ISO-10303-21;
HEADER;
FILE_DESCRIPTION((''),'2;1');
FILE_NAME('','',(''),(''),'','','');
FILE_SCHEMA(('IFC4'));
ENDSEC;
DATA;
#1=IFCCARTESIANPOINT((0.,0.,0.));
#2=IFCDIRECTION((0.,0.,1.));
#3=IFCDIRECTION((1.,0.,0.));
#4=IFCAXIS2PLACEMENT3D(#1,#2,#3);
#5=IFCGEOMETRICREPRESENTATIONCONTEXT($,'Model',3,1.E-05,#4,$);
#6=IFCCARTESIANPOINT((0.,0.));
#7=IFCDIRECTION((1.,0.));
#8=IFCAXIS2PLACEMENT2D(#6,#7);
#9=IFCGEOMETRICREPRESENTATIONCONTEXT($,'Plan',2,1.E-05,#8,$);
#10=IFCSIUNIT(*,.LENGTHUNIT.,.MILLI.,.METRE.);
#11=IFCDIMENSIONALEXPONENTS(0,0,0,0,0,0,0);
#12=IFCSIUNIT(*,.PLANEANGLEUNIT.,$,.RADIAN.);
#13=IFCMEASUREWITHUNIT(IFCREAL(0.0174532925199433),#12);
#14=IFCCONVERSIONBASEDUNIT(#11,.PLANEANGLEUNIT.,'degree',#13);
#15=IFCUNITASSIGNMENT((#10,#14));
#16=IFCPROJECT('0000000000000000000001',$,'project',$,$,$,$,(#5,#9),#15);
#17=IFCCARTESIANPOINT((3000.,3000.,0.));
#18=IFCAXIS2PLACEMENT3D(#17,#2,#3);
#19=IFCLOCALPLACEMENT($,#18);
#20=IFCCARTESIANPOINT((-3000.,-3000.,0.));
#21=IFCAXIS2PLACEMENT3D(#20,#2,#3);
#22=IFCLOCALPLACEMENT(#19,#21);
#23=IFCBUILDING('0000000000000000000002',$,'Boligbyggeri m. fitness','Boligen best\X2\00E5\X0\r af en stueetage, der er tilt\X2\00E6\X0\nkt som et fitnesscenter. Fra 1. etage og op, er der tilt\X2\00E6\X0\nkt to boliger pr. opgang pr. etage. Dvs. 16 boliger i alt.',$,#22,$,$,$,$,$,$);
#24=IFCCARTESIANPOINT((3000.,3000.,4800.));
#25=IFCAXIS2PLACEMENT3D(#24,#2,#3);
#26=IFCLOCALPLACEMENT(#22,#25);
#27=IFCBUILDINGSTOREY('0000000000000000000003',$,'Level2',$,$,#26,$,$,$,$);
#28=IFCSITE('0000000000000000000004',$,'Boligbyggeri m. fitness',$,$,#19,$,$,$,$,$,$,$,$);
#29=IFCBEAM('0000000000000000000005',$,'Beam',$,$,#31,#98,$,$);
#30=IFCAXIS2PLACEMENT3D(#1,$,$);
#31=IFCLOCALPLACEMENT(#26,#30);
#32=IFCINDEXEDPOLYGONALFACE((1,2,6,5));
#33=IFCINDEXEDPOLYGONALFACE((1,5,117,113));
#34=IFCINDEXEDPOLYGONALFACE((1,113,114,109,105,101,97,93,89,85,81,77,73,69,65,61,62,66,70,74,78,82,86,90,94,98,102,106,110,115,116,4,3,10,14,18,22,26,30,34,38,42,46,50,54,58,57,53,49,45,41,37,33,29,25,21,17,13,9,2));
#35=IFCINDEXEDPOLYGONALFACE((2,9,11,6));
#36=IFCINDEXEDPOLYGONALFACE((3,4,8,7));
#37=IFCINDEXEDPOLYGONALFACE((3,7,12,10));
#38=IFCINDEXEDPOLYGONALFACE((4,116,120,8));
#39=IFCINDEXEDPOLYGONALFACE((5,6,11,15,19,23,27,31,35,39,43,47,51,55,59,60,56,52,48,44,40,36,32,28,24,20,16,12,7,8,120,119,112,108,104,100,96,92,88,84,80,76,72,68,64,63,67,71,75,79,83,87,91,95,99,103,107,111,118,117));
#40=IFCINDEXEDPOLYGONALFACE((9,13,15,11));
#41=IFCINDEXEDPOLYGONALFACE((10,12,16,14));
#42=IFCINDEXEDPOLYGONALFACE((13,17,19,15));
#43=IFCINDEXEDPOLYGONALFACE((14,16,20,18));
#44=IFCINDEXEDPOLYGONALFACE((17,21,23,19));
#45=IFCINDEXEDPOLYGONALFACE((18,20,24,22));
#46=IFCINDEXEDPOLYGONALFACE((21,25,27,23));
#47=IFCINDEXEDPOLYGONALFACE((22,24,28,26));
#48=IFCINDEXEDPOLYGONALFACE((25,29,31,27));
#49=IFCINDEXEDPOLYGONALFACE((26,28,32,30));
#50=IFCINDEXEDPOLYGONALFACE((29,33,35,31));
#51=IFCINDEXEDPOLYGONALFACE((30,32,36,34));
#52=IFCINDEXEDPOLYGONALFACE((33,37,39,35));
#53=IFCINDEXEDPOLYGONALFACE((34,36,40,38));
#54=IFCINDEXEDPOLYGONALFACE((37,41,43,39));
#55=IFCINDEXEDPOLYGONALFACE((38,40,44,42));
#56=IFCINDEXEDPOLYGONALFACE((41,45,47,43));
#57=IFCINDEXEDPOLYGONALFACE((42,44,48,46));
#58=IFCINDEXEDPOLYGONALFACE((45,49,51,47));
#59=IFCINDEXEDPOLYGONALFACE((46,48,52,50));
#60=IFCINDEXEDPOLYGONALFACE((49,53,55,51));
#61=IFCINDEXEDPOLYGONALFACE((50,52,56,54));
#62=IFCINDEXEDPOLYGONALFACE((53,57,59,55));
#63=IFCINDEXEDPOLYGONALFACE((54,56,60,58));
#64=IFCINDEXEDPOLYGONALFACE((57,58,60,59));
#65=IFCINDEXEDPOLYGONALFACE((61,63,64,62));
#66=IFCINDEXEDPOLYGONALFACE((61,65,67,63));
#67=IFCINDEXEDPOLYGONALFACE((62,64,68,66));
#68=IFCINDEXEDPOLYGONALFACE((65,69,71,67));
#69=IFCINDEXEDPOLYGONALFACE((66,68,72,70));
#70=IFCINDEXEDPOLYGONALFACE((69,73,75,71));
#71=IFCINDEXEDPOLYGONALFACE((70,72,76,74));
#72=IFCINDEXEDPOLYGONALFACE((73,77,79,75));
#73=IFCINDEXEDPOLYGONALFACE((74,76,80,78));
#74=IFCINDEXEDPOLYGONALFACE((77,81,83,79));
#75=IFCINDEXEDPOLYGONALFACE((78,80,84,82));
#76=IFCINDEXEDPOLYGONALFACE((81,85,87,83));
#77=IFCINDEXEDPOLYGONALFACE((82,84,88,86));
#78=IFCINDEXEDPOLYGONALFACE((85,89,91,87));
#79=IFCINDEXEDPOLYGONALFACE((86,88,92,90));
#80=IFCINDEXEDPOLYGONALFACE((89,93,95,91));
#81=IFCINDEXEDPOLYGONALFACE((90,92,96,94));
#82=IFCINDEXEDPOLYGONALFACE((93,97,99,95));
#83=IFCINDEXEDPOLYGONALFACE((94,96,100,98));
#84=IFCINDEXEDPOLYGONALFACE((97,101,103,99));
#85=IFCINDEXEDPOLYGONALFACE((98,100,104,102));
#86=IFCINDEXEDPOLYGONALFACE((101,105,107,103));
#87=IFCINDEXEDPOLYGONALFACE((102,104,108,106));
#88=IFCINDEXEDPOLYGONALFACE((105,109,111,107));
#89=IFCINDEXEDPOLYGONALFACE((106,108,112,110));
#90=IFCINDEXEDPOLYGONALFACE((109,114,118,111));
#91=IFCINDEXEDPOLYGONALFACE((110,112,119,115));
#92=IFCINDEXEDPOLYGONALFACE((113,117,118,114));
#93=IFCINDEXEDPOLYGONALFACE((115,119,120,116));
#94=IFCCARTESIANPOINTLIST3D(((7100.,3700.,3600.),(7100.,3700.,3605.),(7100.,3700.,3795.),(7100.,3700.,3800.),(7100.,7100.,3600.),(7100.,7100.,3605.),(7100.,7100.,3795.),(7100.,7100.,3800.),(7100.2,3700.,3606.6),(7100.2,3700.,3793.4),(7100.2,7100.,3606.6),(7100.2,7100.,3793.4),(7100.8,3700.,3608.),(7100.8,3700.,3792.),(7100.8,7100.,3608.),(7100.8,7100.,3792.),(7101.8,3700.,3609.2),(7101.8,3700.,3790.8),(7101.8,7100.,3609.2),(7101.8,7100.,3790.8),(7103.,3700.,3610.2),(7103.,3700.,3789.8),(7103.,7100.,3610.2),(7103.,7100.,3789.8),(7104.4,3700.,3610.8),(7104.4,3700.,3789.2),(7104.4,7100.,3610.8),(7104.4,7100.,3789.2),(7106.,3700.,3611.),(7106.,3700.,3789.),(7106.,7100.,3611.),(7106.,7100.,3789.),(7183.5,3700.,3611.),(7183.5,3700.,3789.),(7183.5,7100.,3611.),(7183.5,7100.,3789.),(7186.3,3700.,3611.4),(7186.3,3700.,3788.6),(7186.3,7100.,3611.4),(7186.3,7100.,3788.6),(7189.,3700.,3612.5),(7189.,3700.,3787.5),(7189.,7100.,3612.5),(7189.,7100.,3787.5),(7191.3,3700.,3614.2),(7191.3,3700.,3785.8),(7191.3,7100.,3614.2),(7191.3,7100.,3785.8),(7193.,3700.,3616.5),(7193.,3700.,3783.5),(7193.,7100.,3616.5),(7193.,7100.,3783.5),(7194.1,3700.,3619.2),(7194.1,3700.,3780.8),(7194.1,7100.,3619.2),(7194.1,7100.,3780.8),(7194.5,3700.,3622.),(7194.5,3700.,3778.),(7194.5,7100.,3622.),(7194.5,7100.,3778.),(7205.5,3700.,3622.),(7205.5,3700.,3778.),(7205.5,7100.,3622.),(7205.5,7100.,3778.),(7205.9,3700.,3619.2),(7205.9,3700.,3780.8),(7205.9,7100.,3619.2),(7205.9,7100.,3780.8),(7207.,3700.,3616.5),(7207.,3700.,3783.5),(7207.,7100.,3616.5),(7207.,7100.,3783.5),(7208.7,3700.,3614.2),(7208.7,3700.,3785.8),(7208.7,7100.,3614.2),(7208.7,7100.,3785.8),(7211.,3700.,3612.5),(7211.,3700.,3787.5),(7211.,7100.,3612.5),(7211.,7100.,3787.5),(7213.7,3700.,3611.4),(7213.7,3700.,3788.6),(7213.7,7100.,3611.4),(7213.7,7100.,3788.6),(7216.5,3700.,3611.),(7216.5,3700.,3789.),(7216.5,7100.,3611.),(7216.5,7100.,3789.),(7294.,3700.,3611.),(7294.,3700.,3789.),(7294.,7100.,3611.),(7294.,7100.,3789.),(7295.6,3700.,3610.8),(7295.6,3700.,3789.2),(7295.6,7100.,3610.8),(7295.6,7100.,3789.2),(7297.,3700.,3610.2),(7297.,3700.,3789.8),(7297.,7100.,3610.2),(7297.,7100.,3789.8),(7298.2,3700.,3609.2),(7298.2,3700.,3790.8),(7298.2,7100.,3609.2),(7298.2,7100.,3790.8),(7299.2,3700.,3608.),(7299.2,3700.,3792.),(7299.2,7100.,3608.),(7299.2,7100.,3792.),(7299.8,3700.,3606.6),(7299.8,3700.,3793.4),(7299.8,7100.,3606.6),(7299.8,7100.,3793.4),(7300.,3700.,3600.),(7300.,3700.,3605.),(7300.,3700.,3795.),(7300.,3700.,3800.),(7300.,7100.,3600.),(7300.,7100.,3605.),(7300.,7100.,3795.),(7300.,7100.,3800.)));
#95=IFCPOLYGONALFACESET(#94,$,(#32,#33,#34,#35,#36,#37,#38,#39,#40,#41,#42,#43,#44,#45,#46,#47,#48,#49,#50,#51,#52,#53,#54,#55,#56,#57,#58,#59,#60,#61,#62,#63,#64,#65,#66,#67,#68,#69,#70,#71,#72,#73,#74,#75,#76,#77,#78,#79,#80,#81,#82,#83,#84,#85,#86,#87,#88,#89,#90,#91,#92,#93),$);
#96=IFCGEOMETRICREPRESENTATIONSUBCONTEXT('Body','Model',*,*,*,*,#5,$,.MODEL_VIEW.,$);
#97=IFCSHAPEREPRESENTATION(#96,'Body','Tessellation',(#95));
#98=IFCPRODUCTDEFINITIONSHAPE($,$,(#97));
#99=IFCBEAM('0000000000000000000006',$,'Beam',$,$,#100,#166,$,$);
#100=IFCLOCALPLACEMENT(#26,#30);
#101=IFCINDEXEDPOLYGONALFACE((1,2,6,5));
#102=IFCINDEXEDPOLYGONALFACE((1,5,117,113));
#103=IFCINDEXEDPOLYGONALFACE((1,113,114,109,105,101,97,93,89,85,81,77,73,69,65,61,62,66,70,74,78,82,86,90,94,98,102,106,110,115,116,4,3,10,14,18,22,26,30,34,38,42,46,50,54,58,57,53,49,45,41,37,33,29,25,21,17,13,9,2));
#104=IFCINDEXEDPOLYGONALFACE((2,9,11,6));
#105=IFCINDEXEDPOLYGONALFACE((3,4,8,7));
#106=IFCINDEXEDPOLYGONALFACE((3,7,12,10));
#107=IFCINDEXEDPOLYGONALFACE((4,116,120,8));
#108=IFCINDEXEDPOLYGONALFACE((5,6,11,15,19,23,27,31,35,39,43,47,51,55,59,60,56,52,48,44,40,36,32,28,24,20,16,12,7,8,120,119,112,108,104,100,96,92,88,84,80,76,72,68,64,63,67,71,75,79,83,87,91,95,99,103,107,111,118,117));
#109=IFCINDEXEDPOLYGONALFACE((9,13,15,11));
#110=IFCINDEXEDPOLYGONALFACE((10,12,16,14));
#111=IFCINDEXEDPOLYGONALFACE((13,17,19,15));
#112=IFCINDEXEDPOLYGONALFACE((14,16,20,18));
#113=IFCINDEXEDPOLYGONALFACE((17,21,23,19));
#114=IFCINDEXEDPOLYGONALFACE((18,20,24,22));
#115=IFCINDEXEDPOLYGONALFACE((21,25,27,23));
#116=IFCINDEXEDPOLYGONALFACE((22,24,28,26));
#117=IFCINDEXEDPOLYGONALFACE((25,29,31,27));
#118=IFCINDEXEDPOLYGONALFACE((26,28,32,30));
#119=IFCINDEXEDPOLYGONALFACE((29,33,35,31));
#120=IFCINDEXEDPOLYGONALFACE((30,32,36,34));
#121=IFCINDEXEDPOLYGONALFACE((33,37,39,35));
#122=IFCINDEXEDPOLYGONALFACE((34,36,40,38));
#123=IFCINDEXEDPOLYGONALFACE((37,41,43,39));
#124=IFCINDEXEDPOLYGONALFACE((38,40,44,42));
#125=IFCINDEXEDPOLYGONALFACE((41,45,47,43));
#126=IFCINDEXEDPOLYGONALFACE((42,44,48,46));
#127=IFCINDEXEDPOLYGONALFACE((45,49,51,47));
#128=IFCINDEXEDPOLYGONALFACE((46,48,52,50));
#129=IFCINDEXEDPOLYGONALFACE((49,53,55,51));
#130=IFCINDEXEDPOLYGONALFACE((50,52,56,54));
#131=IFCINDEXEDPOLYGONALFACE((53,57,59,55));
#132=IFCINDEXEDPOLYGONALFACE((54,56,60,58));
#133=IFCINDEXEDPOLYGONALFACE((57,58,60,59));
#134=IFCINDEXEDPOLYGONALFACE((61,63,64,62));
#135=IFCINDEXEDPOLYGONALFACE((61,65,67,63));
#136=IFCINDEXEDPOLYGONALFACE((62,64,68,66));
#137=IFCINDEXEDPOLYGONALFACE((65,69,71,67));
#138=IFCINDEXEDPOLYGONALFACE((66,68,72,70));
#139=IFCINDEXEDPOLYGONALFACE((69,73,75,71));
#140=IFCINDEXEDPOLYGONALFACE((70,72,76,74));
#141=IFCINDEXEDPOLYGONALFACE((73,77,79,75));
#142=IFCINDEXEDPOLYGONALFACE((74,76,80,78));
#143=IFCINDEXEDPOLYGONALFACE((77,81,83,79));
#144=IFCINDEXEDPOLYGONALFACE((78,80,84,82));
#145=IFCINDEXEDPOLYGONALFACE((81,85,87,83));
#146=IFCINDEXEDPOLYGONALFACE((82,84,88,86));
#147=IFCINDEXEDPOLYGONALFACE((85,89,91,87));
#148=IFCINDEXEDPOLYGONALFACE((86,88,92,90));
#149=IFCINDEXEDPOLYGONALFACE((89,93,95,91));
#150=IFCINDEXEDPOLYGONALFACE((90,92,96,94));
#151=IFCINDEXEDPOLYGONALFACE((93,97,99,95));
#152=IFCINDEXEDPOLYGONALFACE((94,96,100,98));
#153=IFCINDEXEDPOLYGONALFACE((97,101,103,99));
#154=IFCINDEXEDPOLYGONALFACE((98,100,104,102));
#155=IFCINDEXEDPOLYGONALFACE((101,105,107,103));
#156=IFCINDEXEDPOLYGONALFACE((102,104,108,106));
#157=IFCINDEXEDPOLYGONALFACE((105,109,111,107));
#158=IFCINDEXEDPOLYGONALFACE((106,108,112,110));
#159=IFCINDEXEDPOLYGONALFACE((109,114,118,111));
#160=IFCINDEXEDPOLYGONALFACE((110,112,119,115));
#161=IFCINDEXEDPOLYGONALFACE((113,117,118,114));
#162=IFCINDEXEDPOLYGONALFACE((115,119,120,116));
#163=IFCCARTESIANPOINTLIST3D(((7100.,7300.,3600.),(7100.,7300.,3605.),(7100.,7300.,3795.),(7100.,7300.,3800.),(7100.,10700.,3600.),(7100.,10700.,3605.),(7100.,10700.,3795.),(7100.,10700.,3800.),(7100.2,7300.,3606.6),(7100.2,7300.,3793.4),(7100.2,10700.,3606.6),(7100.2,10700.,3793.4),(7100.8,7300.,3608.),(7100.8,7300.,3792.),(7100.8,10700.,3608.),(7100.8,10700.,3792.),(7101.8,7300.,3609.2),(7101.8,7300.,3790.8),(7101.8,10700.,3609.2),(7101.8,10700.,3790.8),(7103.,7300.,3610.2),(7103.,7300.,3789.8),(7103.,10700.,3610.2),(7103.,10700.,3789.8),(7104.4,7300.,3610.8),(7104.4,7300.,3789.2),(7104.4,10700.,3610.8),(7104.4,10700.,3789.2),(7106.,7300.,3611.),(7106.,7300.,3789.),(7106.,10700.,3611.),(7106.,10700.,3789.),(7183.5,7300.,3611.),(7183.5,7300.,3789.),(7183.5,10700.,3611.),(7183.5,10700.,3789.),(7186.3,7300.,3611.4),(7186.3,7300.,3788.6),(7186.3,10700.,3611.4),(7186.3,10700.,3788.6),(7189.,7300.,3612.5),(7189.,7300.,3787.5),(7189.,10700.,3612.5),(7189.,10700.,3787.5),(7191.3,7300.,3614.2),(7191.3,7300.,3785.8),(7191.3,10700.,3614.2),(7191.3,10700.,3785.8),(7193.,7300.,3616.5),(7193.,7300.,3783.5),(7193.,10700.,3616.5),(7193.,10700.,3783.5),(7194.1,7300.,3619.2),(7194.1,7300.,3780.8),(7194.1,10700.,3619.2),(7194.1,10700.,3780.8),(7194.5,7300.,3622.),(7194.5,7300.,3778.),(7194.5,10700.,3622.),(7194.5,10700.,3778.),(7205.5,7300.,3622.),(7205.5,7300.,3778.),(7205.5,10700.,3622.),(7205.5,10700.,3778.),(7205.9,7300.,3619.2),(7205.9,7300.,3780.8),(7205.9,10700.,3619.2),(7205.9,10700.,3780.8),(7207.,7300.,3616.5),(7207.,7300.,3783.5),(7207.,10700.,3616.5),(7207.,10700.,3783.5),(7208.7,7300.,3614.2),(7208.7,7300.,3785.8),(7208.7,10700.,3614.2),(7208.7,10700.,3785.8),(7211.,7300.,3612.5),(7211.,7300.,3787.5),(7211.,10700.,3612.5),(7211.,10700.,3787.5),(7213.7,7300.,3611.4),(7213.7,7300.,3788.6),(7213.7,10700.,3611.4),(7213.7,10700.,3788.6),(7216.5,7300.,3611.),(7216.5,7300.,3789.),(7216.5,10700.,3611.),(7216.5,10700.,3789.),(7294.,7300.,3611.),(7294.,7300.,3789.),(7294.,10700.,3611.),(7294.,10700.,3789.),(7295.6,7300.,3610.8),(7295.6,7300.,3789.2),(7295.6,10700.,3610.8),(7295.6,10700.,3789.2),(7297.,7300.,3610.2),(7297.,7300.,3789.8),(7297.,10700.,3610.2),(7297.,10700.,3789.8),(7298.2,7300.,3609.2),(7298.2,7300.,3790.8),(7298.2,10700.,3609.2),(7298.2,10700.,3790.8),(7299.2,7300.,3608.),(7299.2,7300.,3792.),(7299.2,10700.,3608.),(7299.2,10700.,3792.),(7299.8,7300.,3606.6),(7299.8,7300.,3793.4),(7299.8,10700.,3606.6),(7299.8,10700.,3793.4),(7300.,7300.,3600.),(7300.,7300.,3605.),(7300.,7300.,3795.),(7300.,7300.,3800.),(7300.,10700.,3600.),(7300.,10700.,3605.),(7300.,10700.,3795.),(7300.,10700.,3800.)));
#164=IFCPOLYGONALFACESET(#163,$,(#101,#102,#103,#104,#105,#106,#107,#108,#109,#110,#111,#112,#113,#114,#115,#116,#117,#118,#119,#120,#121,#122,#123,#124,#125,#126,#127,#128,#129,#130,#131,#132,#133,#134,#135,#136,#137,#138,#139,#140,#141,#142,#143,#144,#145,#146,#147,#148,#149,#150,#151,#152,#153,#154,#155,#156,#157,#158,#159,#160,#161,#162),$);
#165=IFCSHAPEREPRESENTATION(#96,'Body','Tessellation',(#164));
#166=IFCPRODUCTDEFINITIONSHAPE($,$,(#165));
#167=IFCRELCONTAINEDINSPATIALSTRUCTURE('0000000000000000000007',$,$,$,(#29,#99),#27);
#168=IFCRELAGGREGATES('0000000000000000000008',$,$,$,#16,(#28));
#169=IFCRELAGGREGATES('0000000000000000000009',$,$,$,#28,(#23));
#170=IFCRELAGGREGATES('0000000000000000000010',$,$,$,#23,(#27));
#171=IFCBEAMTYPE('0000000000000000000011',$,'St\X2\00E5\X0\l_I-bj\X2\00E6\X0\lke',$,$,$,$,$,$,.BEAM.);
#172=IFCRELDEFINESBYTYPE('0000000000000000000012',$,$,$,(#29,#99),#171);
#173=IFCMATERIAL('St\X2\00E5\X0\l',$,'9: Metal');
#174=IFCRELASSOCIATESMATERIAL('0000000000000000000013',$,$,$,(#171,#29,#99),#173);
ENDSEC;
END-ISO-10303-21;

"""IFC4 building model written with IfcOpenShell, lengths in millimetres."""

from ifc_helpers import new_model, entity, si_unit, converted_unit, frame, origin_with_axes, origin_2d_with_axis, place, context, subcontext, project, spatial, i_section, extrude, material, material_profile, profile_set, profile_usage, type_object, element, save


model = new_model("IFC4")

# Units and contexts
model_context = context("Model", 3, precision=1e-05, world=origin_with_axes())
plan_context = context("Plan", 2, precision=1e-05, world=origin_2d_with_axis())
body_context = subcontext(model_context, "Body", "Model", "MODEL_VIEW")
ifc_project = project(units=[si_unit("LENGTHUNIT", "METRE", prefix="MILLI"), converted_unit("PLANEANGLEUNIT", "degree", entity("IfcReal", 0.0174532925199433), si_unit("PLANEANGLEUNIT", "RADIAN"), dimensions=[0, 0, 0, 0, 0, 0, 0])], contexts=[model_context, plan_context])

# Site, building, storey
site_placement = place(None, frame((3000.0, 3000.0, 0.0), z_axis=(0.0, 0.0, 1.0), x_axis=(1.0, 0.0, 0.0)))
site = spatial("IfcSite", under=ifc_project, at=site_placement, Name="Boligbyggeri m. fitness")
building_placement = place(site_placement, frame((-3000.0, -3000.0, 0.0), z_axis=(0.0, 0.0, 1.0), x_axis=(1.0, 0.0, 0.0)))
building = spatial("IfcBuilding", under=site, at=building_placement, Name="Boligbyggeri m. fitness", Description="Boligen består af en stueetage, der er tiltænkt som et fitnesscenter. Fra 1. etage og op, er der tiltænkt to boliger pr. opgang pr. etage. Dvs. 16 boliger i alt.")
storey_placement = place(building_placement, frame((3000.0, 3000.0, 4800.0), z_axis=(0.0, 0.0, 1.0), x_axis=(1.0, 0.0, 0.0)))
storey = spatial("IfcBuildingStorey", under=building, at=storey_placement, Name="Level2")

# Beams
ifc_material_1 = material(Name="Stål", Category="9: Metal")
ifc_material_profile_1 = material_profile(ifc_material_1, i_section(OverallWidth=200.0, OverallDepth=200.0, WebThickness=11.0, FlangeThickness=11.0, FilletRadius=11.0, FlangeEdgeRadius=6.0), Name="Stål", Category="9: Metal")
ifc_profile_set_1 = profile_set([ifc_material_profile_1], Name="NY_I-Profil")
beam_type = type_object("IfcBeamType", Name="Stål_I-bjælke", PredefinedType="BEAM", material=ifc_profile_set_1)
ifc_profile_usage_1 = profile_usage(ifc_profile_set_1, cardinal=9)
beam_1_placement = place(storey_placement, frame((7300.0, 3700.0, 3800.0), z_axis=(0.0, 1.0, 0.0), x_axis=(-1.0, 0.0, 0.0)))
element("IfcBeam", 1, at=beam_1_placement, inside=storey, type_object=beam_type, material=ifc_profile_usage_1, Name="Beam", context=body_context, shape_type="SweptSolid", body=[
    extrude(i_section(OverallWidth=200.0, OverallDepth=200.0, WebThickness=11.0, FlangeThickness=11.0, FilletRadius=11.0, FlangeEdgeRadius=6.0), frame((100.0, -100.0, 0.0), z_axis=(0.0, 0.0, 1.0), x_axis=(1.0, 0.0, 0.0)), (0.0, 0.0, 1.0), 3400.0),
])
ifc_profile_usage_2 = profile_usage(ifc_profile_set_1, cardinal=9)
beam_2_placement = place(storey_placement, frame((7300.0, 7300.0, 3800.0), z_axis=(0.0, 1.0, 0.0), x_axis=(-1.0, 0.0, 0.0)))
element("IfcBeam", 2, at=beam_2_placement, inside=storey, type_object=beam_type, material=ifc_profile_usage_2, Name="Beam", context=body_context, shape_type="SweptSolid", body=[
    extrude(i_section(OverallWidth=200.0, OverallDepth=200.0, WebThickness=11.0, FlangeThickness=11.0, FilletRadius=11.0, FlangeEdgeRadius=6.0), frame((100.0, -100.0, 0.0), z_axis=(0.0, 0.0, 1.0), x_axis=(1.0, 0.0, 0.0)), (0.0, 0.0, 1.0), 3400.0),
])

save(model, "model.ifc")
